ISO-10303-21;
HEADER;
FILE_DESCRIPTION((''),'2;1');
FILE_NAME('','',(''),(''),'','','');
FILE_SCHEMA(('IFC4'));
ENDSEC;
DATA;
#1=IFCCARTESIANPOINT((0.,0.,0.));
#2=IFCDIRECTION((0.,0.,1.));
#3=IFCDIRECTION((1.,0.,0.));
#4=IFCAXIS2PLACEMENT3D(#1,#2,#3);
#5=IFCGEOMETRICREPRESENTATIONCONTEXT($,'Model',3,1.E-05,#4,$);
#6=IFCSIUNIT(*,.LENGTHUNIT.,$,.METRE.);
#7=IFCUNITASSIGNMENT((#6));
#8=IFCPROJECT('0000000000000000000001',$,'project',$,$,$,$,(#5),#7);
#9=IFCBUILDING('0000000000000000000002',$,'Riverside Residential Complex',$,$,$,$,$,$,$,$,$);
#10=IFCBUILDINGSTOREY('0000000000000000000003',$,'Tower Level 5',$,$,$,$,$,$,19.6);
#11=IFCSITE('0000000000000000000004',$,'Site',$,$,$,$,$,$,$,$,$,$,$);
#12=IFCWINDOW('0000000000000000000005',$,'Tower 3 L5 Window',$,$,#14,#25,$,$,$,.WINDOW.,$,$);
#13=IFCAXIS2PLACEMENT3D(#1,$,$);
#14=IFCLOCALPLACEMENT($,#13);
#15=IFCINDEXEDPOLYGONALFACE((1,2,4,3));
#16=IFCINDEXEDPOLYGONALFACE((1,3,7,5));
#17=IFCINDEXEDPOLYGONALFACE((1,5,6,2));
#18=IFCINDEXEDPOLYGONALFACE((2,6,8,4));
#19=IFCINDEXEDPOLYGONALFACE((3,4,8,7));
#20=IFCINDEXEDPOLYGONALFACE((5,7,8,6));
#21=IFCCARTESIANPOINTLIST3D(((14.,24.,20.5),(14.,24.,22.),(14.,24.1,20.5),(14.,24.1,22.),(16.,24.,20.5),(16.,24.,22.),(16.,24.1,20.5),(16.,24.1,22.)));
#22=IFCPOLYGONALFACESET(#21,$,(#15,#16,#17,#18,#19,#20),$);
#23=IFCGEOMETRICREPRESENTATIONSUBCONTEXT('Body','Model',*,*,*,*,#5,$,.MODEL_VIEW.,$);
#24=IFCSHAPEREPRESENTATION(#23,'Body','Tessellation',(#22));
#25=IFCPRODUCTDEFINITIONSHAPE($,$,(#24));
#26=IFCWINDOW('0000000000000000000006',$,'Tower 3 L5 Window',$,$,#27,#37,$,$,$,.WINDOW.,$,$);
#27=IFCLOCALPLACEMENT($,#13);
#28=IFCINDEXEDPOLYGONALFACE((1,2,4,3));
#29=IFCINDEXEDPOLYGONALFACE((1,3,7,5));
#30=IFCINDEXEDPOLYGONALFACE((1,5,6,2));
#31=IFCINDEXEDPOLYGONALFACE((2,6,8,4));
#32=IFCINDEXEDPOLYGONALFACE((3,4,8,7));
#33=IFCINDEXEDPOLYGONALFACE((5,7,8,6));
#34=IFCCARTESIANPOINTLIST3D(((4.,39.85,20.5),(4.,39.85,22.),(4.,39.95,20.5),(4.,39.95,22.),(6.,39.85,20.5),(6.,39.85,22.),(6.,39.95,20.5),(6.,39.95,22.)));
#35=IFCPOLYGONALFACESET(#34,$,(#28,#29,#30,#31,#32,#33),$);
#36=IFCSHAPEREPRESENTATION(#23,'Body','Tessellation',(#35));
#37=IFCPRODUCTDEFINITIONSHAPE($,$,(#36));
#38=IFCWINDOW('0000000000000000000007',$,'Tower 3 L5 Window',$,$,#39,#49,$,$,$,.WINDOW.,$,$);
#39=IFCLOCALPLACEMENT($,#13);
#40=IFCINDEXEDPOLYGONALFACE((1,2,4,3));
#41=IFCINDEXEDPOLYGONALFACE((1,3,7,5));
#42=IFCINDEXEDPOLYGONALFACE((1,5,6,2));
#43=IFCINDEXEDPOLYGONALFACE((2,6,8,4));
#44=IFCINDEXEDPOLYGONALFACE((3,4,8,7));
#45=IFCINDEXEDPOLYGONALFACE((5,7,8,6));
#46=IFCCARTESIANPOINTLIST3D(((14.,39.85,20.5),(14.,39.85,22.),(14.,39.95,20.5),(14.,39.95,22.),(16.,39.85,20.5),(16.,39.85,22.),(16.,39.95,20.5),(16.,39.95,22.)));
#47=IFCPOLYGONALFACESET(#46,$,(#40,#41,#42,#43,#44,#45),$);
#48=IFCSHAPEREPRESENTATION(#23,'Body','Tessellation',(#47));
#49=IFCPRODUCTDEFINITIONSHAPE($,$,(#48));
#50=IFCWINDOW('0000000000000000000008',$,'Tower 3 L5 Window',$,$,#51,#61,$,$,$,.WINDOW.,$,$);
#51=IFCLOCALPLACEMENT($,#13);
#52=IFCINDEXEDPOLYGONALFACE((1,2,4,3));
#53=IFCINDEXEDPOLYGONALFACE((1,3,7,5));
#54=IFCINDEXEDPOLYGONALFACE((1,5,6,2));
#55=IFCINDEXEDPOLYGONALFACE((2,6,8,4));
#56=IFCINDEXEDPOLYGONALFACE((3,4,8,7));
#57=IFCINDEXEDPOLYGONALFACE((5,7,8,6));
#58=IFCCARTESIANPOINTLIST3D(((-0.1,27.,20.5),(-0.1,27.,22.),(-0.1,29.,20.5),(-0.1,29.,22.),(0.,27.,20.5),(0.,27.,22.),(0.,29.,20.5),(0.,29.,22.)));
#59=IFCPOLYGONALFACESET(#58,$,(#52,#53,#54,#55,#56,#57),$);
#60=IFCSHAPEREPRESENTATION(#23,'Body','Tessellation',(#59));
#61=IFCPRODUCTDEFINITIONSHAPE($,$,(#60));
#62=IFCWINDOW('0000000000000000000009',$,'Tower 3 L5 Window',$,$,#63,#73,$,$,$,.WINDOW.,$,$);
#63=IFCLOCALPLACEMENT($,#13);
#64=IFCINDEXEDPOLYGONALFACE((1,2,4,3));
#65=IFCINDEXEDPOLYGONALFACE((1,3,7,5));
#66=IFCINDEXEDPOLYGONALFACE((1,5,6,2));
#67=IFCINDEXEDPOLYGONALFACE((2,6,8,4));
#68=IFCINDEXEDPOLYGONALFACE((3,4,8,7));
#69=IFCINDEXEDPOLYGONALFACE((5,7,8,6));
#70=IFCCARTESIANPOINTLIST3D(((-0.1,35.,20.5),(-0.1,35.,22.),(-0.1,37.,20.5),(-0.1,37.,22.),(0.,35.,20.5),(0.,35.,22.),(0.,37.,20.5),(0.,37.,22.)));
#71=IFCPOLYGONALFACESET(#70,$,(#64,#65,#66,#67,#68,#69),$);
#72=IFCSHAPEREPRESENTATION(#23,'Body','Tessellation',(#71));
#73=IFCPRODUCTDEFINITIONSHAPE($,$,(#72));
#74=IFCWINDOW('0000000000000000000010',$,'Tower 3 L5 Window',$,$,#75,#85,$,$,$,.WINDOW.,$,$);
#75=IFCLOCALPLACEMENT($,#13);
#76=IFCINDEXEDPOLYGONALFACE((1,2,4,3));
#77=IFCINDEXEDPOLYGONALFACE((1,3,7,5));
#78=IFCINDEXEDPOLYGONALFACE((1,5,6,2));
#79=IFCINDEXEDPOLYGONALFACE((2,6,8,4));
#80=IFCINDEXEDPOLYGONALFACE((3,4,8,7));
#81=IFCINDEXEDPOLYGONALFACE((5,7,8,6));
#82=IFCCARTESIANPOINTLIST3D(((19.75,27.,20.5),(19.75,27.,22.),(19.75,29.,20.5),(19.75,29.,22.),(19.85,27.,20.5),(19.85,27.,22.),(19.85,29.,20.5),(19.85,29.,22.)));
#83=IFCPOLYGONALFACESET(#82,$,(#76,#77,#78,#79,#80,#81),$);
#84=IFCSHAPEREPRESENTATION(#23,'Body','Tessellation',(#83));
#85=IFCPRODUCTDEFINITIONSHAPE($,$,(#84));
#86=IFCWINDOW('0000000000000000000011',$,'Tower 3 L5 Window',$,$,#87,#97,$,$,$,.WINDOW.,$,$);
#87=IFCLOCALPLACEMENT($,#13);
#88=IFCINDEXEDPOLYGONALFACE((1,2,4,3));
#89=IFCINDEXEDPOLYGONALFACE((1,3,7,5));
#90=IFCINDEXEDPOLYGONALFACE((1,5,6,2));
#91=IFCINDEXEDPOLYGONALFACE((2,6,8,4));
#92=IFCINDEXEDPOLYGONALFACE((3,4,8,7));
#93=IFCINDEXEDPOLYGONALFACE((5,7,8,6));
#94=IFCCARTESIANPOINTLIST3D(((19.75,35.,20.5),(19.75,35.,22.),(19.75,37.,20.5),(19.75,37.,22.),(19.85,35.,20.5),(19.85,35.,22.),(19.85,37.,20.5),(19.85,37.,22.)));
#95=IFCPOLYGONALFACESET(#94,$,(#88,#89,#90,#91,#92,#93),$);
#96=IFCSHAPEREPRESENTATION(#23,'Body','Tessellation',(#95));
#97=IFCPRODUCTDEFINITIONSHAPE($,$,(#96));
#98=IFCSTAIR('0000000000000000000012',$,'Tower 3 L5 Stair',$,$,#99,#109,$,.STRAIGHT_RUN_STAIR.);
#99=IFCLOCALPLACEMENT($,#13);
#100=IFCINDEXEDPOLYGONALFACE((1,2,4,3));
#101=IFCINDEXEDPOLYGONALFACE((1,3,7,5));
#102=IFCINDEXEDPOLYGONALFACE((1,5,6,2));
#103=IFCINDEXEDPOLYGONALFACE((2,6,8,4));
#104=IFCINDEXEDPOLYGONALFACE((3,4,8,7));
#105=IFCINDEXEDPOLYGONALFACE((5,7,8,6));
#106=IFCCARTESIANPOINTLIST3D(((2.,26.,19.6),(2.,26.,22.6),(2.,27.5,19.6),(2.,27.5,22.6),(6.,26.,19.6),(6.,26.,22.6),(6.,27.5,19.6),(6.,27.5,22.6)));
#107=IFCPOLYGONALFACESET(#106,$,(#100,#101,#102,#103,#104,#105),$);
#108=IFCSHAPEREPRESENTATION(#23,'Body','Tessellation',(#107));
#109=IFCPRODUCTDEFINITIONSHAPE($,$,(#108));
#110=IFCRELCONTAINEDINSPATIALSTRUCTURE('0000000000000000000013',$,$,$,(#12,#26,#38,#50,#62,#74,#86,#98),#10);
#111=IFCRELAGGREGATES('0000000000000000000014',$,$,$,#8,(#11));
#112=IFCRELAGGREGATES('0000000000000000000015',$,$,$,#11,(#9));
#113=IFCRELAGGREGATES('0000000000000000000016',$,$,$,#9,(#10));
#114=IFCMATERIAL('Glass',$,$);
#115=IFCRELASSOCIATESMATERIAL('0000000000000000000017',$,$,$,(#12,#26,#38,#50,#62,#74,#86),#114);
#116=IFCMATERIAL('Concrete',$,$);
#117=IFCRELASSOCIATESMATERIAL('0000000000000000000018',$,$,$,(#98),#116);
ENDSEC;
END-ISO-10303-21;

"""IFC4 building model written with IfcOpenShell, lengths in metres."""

from ifc_helpers import new_model, si_unit, frame, origin_with_axes, place, context, subcontext, project, spatial, line, indexed_curve, outline, extrude, material, element, save


model = new_model("IFC4")

# Units and contexts
model_context = context("Model", 3, precision=1e-05, world=origin_with_axes())
body_context = subcontext(model_context, "Body", "Model", "MODEL_VIEW")
ifc_project = project(units=[si_unit("LENGTHUNIT", "METRE")], contexts=[model_context])

# Site, building, storey
site = spatial("IfcSite", under=ifc_project, Name="Site")
building = spatial("IfcBuilding", under=site, Name="Riverside Residential Complex")
storey = spatial("IfcBuildingStorey", under=building, Name="Tower Level 5", Elevation=19.6)

# Shared definitions
ifc_material_1 = material(Name="Concrete")

# Windows
ifc_material_2 = material(Name="Glass")
for number, where, z_axis, x_axis, name in (
    (1, (14.0, 24.0, 20.5), (0.0, 0.0, 1.0), (1.0, 0.0, 0.0), "Tower 3 L5 Window"),
    (2, (4.0, 39.85, 20.5), (0.0, 0.0, 1.0), (1.0, 0.0, 0.0), "Tower 3 L5 Window"),
    (3, (14.0, 39.85, 20.5), (0.0, 0.0, 1.0), (1.0, 0.0, 0.0), "Tower 3 L5 Window"),
    (4, (0.0, 27.0, 20.5), (0.0, 0.0, 1.0), (0.0, 1.0, 0.0), "Tower 3 L5 Window"),
    (5, (0.0, 35.0, 20.5), (0.0, 0.0, 1.0), (0.0, 1.0, 0.0), "Tower 3 L5 Window"),
    (6, (19.85, 27.0, 20.5), (0.0, 0.0, 1.0), (0.0, 1.0, 0.0), "Tower 3 L5 Window"),
    (7, (19.85, 35.0, 20.5), (0.0, 0.0, 1.0), (0.0, 1.0, 0.0), "Tower 3 L5 Window"),
):
    element("IfcWindow", number, at=place(None, frame(where, z_axis=z_axis, x_axis=x_axis)), inside=storey, material=ifc_material_2, Name=name, PredefinedType="WINDOW", context=body_context, shape_type="SweptSolid", body=[
        extrude(outline(indexed_curve([(0.0, 0.0), (2.0, 0.0), (2.0, 0.1), (0.0, 0.1)], segments=[line(1, 2, 3, 4, 1)])), origin_with_axes(), (0.0, 0.0, 1.0), 1.5),
    ])

# Stair
stair_placement = place(None, frame((2.0, 26.0, 19.6), z_axis=(0.0, 0.0, 1.0), x_axis=(1.0, 0.0, 0.0)))
element("IfcStair", 8, at=stair_placement, inside=storey, material=ifc_material_1, Name="Tower 3 L5 Stair", PredefinedType="STRAIGHT_RUN_STAIR", context=body_context, shape_type="SweptSolid", body=[
    extrude(outline(indexed_curve([(0.0, 0.0), (4.0, 0.0), (4.0, 1.5), (0.0, 1.5)], segments=[line(1, 2, 3, 4, 1)])), origin_with_axes(), (0.0, 0.0, 1.0), 3.0),
])

save(model, "model.ifc")
